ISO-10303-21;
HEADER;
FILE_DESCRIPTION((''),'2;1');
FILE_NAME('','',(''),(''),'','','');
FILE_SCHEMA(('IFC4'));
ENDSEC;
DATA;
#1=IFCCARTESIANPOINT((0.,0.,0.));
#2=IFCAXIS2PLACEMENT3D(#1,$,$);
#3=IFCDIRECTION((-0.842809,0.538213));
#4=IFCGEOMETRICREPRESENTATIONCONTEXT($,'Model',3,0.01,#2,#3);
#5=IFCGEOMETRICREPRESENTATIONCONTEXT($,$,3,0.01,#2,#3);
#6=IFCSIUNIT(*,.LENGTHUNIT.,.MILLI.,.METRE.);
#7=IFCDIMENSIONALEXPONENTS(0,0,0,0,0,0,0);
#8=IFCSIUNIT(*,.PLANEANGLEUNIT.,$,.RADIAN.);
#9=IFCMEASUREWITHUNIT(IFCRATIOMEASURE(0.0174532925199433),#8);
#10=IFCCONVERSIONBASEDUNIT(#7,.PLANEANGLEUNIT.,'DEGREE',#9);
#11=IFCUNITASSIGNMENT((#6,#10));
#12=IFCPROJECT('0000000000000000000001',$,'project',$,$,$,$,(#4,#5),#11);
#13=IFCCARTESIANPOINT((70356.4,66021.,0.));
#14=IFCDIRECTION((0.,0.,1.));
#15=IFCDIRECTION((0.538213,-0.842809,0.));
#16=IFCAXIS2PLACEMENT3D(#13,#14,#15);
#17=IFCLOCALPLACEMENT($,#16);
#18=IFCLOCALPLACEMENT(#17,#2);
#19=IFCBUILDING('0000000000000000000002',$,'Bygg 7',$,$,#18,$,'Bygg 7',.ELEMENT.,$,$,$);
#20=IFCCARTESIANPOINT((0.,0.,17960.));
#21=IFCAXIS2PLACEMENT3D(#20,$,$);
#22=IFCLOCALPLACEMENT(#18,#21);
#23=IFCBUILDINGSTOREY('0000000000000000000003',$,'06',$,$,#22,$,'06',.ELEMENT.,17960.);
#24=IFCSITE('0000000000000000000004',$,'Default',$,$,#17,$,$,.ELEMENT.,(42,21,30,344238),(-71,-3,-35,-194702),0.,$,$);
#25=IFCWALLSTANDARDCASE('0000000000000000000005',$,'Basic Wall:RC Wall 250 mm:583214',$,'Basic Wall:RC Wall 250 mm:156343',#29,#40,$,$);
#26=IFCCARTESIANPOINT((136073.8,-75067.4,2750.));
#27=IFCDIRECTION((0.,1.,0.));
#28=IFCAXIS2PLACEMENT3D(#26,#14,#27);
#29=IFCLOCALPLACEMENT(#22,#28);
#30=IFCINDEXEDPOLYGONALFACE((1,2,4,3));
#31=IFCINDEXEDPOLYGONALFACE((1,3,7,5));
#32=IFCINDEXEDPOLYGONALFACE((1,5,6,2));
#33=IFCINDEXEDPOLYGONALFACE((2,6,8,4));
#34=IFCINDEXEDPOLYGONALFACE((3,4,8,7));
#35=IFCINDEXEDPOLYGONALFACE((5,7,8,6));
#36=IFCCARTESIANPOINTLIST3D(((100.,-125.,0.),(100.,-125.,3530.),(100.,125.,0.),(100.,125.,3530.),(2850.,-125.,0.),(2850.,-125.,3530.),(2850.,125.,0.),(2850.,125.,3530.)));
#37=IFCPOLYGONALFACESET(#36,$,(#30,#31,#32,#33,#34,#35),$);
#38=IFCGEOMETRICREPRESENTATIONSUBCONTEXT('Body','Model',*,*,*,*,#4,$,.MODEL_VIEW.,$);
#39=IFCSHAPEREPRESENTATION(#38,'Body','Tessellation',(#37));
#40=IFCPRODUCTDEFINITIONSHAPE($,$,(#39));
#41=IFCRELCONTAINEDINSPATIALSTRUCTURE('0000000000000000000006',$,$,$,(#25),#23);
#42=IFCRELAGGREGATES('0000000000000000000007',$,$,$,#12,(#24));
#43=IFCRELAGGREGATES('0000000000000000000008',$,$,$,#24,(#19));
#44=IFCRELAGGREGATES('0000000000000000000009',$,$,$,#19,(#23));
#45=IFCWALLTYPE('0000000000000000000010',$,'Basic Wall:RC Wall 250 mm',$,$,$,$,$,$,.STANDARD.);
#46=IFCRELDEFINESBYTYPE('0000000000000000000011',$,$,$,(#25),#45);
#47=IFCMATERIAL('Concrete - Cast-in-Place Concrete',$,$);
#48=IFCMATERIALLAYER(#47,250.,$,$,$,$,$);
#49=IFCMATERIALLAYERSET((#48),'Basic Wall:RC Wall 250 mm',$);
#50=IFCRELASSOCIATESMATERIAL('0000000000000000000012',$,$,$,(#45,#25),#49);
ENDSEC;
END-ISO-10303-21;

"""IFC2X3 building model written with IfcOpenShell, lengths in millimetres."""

from ifc_helpers import new_model, entity, si_unit, converted_unit, direction, frame, frame_2d, origin, place, context, subcontext, project, spatial, polyline, rectangle, extrude, clip, bounded_halfspace, material, layer, layer_set, layer_usage, type_object, element, save


model = new_model("IFC2X3")

# Units and contexts
model_context = context("Model", 3, precision=0.01, world=origin(), true_north=direction((-0.842809, 0.538213)))
context_of_model = context(None, 3, precision=0.01, world=origin(), true_north=direction((-0.842809, 0.538213)))
body_context = subcontext(model_context, "Body", "Model", "MODEL_VIEW")
ifc_project = project(units=[si_unit("LENGTHUNIT", "METRE", prefix="MILLI"), converted_unit("PLANEANGLEUNIT", "DEGREE", entity("IfcRatioMeasure", 0.0174532925199433), si_unit("PLANEANGLEUNIT", "RADIAN"), dimensions=[0, 0, 0, 0, 0, 0, 0])], contexts=[model_context, context_of_model])

# Site, building, storey
site_placement = place(None, frame((70356.4, 66021.0, 0.0), z_axis=(0.0, 0.0, 1.0), x_axis=(0.538213, -0.842809, 0.0)))
site = spatial("IfcSite", under=ifc_project, at=site_placement, Name="Default", CompositionType="ELEMENT", RefLatitude=(42, 21, 30, 344238), RefLongitude=(-71, -3, -35, -194702), RefElevation=0.0)
building_placement = place(site_placement, origin())
building = spatial("IfcBuilding", under=site, at=building_placement, Name="Bygg 7", LongName="Bygg 7", CompositionType="ELEMENT")
storey_placement = place(building_placement, frame((0.0, 0.0, 17960.0)))
storey = spatial("IfcBuildingStorey", under=building, at=storey_placement, Name="06", LongName="06", CompositionType="ELEMENT", Elevation=17960.0)

# Shared definitions
ifc_material_1 = material(Name="Concrete - Cast-in-Place Concrete")

# Shared definitions
ifc_layer_1 = layer(ifc_material_1, 250.0)
ifc_layer_set_1 = layer_set([ifc_layer_1], Name="Basic Wall:RC Wall 250 mm")
wall_type_1 = type_object("IfcWallType", Name="Basic Wall:RC Wall 250 mm", PredefinedType="STANDARD", material=ifc_layer_set_1)

# Wall
ifc_layer_usage_1 = layer_usage(ifc_layer_set_1, "AXIS2", "NEGATIVE", 125.0)
wall_1_placement = place(storey_placement, frame((136073.8, -75067.4, 2750.0), z_axis=(0.0, 0.0, 1.0), x_axis=(0.0, 1.0, 0.0)))
element("IfcWallStandardCase", 1, at=wall_1_placement, inside=storey, type_object=wall_type_1, material=ifc_layer_usage_1, Name="Basic Wall:RC Wall 250 mm:583214", ObjectType="Basic Wall:RC Wall 250 mm:156343", context=body_context, shape_type="Clipping", body=[
    clip(clip(extrude(rectangle(XDim=2750.0, YDim=250.0, at=frame_2d((1475.0, 0.0), x_axis=(-1.0, 0.0))), origin(), (0.0, 0.0, 1.0), 3530.0), bounded_halfspace(frame((2850.0, -125.0, 0.0), z_axis=(0.0, 0.0, 1.0), x_axis=(0.99571, 0.092529, 0.0)), True, frame((2850.0, -125.0, 0.0)), polyline([(0.0, 0.0), (0.0, 111.0), (0.0, 250.0), (-2750.0, 250.0), (-2750.0, 111.0), (-2750.0, 0.0), (0.0, 0.0)]))), bounded_halfspace(frame((0.0, -125.0, 3530.0), z_axis=(0.0, 0.0, -1.0), x_axis=(0.0, -1.0, 0.0)), True, frame((0.0, -125.0, 3530.0)), polyline([(0.0, 0.0), (2850.0, 0.0), (2850.0, 250.0), (2600.0, 250.0), (200.0, 250.0), (0.0, 250.0), (0.0, 0.0)]))),
])

save(model, "model.ifc")
